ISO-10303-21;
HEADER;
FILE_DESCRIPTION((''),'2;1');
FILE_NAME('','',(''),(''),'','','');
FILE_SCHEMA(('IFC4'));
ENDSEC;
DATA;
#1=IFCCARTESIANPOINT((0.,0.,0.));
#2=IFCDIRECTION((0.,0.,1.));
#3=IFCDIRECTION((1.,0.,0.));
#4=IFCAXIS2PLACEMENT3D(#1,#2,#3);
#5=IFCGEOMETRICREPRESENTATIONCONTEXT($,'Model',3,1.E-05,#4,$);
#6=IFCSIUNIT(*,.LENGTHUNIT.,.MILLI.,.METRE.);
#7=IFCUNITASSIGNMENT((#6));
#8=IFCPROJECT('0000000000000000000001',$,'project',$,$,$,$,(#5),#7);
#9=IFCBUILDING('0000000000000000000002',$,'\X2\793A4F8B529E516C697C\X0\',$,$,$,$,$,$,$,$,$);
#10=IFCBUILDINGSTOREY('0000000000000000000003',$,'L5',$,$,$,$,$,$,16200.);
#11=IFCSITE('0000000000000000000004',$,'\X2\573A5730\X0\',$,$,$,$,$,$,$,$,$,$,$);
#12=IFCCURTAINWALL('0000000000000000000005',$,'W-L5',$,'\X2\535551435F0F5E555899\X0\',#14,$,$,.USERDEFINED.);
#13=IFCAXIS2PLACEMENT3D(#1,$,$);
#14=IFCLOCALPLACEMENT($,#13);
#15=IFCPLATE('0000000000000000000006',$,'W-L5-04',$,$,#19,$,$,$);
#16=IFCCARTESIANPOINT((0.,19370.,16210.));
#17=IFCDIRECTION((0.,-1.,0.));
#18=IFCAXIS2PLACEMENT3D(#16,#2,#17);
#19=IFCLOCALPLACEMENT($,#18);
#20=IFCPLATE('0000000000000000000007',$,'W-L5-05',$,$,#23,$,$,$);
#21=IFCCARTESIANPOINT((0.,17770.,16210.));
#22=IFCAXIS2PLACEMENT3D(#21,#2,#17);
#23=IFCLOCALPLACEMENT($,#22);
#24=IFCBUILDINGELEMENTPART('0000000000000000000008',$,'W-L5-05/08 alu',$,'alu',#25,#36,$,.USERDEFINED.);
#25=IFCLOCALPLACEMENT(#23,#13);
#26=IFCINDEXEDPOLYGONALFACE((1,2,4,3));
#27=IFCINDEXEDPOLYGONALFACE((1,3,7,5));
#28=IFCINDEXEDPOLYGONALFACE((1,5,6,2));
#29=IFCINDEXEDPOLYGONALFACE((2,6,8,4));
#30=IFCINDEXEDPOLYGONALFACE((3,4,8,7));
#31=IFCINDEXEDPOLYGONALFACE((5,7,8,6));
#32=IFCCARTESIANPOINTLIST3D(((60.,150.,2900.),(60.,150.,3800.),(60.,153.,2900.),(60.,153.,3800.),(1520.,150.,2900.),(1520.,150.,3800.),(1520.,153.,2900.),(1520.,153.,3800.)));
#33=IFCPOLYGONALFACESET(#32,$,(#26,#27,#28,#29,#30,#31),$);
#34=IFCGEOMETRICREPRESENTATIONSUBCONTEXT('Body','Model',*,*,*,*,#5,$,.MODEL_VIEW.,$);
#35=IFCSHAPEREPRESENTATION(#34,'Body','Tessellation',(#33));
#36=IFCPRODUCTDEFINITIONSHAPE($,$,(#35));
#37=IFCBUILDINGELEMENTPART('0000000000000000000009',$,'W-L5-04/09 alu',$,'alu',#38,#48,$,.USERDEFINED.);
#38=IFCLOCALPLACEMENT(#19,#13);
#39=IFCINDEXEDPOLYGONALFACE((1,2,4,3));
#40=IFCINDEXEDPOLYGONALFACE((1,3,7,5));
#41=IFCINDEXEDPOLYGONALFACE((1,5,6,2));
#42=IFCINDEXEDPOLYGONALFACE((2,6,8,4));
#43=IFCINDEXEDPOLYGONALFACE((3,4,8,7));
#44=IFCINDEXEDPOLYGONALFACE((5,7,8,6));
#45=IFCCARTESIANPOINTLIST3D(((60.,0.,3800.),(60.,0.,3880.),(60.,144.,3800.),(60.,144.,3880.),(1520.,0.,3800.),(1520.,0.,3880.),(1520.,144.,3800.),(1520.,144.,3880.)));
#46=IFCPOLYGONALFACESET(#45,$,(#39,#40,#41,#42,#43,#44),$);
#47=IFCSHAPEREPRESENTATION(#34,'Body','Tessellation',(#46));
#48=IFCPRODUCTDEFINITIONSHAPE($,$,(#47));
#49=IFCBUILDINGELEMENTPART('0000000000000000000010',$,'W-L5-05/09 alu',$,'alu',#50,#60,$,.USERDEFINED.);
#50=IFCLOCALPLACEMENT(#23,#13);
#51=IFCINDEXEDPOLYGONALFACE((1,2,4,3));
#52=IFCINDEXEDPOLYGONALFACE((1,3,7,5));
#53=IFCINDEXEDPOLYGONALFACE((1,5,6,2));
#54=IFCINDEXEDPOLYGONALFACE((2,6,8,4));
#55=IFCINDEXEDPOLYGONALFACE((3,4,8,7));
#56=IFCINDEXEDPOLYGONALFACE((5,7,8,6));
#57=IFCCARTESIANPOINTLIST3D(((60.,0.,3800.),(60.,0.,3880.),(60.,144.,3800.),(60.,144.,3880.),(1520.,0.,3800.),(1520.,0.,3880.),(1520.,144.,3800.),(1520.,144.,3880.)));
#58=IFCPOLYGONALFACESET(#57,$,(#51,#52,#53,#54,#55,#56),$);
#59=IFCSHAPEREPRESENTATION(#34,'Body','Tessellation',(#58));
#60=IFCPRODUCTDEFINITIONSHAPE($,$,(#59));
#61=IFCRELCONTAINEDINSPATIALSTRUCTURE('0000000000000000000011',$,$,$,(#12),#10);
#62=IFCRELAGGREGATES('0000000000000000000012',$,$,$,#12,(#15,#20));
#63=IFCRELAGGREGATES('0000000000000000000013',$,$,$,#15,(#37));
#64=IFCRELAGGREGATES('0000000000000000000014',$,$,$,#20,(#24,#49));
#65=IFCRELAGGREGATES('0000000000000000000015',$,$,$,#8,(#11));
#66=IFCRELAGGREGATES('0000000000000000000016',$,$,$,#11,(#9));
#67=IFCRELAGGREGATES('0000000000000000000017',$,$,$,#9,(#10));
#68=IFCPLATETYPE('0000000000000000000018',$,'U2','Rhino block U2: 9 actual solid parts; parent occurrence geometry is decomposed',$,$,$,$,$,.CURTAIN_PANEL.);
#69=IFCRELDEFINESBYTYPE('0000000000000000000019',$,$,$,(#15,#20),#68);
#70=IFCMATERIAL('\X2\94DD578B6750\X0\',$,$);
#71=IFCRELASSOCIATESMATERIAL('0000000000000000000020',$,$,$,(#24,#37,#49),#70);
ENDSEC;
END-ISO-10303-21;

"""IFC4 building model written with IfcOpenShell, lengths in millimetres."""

from ifc_helpers import new_model, si_unit, frame, frame_2d, origin, origin_with_axes, place, context, subcontext, project, spatial, rectangle, extrude, source, transform, mapped, material, type_object, element, aggregate, save


model = new_model("IFC4")

# Units and contexts
model_context = context("Model", 3, precision=1e-05, world=origin_with_axes())
body_context = subcontext(model_context, "Body", "Model", "MODEL_VIEW")
ifc_project = project(units=[si_unit("LENGTHUNIT", "METRE", prefix="MILLI")], contexts=[model_context])

# Site, building, storey
site = spatial("IfcSite", under=ifc_project, Name="场地")
building = spatial("IfcBuilding", under=site, Name="示例办公楼")
storey = spatial("IfcBuildingStorey", under=building, Name="L5", Elevation=16200.0)

# Curtain wall, plates, building element parts
curtain_wall = element("IfcCurtainWall", 1, inside=storey, Name="W-L5", ObjectType="单元式幕墙", PredefinedType="USERDEFINED")
plate_type = type_object("IfcPlateType", Name="U2", Description="Rhino block U2: 9 actual solid parts; parent occurrence geometry is decomposed", PredefinedType="CURTAIN_PANEL")
ifc_material_1 = material(Name="铝型材")
plate_1_placement = place(None, frame((0.0, 19370.0, 16210.0), z_axis=(0.0, 0.0, 1.0), x_axis=(0.0, -1.0, 0.0)))
plate_1 = element("IfcPlate", 2, at=plate_1_placement, type_object=plate_type, Name="W-L5-04")
plate_2_placement = place(None, frame((0.0, 17770.0, 16210.0), z_axis=(0.0, 0.0, 1.0), x_axis=(0.0, -1.0, 0.0)))
plate_2 = element("IfcPlate", 3, at=plate_2_placement, type_object=plate_type, Name="W-L5-05")
aggregate(curtain_wall, [plate_1, plate_2])
shared_shape_1 = source(origin(), body_context, "Body", "SweptSolid", [
    extrude(rectangle(XDim=1460.0, YDim=3.0, at=frame_2d((790.0, 151.5))), frame((0.0, 0.0, 2900.0)), (0.0, 0.0, 1.0), 900.0),
])
building_element_part_1_placement = place(plate_2_placement, origin())
building_element_part_1 = element("IfcBuildingElementPart", 4, at=building_element_part_1_placement, material=ifc_material_1, Name="W-L5-05/08 alu", ObjectType="alu", PredefinedType="USERDEFINED", context=body_context, shape_type="MappedRepresentation", body=[
    mapped(shared_shape_1, transform((0.0, 0.0, 0.0))),
])
shared_shape_2 = source(origin(), body_context, "Body", "SweptSolid", [
    extrude(rectangle(XDim=1460.0, YDim=144.0, at=frame_2d((790.0, 72.0))), frame((0.0, 0.0, 3800.0)), (0.0, 0.0, 1.0), 80.0),
])
building_element_part_2_placement = place(plate_1_placement, origin())
building_element_part_2 = element("IfcBuildingElementPart", 5, at=building_element_part_2_placement, material=ifc_material_1, Name="W-L5-04/09 alu", ObjectType="alu", PredefinedType="USERDEFINED", context=body_context, shape_type="MappedRepresentation", body=[
    mapped(shared_shape_2, transform((0.0, 0.0, 0.0))),
])
aggregate(plate_1, [building_element_part_2])
building_element_part_3_placement = place(plate_2_placement, origin())
building_element_part_3 = element("IfcBuildingElementPart", 6, at=building_element_part_3_placement, material=ifc_material_1, Name="W-L5-05/09 alu", ObjectType="alu", PredefinedType="USERDEFINED", context=body_context, shape_type="MappedRepresentation", body=[
    mapped(shared_shape_2, transform((0.0, 0.0, 0.0))),
])
aggregate(plate_2, [building_element_part_1, building_element_part_3])

save(model, "model.ifc")
